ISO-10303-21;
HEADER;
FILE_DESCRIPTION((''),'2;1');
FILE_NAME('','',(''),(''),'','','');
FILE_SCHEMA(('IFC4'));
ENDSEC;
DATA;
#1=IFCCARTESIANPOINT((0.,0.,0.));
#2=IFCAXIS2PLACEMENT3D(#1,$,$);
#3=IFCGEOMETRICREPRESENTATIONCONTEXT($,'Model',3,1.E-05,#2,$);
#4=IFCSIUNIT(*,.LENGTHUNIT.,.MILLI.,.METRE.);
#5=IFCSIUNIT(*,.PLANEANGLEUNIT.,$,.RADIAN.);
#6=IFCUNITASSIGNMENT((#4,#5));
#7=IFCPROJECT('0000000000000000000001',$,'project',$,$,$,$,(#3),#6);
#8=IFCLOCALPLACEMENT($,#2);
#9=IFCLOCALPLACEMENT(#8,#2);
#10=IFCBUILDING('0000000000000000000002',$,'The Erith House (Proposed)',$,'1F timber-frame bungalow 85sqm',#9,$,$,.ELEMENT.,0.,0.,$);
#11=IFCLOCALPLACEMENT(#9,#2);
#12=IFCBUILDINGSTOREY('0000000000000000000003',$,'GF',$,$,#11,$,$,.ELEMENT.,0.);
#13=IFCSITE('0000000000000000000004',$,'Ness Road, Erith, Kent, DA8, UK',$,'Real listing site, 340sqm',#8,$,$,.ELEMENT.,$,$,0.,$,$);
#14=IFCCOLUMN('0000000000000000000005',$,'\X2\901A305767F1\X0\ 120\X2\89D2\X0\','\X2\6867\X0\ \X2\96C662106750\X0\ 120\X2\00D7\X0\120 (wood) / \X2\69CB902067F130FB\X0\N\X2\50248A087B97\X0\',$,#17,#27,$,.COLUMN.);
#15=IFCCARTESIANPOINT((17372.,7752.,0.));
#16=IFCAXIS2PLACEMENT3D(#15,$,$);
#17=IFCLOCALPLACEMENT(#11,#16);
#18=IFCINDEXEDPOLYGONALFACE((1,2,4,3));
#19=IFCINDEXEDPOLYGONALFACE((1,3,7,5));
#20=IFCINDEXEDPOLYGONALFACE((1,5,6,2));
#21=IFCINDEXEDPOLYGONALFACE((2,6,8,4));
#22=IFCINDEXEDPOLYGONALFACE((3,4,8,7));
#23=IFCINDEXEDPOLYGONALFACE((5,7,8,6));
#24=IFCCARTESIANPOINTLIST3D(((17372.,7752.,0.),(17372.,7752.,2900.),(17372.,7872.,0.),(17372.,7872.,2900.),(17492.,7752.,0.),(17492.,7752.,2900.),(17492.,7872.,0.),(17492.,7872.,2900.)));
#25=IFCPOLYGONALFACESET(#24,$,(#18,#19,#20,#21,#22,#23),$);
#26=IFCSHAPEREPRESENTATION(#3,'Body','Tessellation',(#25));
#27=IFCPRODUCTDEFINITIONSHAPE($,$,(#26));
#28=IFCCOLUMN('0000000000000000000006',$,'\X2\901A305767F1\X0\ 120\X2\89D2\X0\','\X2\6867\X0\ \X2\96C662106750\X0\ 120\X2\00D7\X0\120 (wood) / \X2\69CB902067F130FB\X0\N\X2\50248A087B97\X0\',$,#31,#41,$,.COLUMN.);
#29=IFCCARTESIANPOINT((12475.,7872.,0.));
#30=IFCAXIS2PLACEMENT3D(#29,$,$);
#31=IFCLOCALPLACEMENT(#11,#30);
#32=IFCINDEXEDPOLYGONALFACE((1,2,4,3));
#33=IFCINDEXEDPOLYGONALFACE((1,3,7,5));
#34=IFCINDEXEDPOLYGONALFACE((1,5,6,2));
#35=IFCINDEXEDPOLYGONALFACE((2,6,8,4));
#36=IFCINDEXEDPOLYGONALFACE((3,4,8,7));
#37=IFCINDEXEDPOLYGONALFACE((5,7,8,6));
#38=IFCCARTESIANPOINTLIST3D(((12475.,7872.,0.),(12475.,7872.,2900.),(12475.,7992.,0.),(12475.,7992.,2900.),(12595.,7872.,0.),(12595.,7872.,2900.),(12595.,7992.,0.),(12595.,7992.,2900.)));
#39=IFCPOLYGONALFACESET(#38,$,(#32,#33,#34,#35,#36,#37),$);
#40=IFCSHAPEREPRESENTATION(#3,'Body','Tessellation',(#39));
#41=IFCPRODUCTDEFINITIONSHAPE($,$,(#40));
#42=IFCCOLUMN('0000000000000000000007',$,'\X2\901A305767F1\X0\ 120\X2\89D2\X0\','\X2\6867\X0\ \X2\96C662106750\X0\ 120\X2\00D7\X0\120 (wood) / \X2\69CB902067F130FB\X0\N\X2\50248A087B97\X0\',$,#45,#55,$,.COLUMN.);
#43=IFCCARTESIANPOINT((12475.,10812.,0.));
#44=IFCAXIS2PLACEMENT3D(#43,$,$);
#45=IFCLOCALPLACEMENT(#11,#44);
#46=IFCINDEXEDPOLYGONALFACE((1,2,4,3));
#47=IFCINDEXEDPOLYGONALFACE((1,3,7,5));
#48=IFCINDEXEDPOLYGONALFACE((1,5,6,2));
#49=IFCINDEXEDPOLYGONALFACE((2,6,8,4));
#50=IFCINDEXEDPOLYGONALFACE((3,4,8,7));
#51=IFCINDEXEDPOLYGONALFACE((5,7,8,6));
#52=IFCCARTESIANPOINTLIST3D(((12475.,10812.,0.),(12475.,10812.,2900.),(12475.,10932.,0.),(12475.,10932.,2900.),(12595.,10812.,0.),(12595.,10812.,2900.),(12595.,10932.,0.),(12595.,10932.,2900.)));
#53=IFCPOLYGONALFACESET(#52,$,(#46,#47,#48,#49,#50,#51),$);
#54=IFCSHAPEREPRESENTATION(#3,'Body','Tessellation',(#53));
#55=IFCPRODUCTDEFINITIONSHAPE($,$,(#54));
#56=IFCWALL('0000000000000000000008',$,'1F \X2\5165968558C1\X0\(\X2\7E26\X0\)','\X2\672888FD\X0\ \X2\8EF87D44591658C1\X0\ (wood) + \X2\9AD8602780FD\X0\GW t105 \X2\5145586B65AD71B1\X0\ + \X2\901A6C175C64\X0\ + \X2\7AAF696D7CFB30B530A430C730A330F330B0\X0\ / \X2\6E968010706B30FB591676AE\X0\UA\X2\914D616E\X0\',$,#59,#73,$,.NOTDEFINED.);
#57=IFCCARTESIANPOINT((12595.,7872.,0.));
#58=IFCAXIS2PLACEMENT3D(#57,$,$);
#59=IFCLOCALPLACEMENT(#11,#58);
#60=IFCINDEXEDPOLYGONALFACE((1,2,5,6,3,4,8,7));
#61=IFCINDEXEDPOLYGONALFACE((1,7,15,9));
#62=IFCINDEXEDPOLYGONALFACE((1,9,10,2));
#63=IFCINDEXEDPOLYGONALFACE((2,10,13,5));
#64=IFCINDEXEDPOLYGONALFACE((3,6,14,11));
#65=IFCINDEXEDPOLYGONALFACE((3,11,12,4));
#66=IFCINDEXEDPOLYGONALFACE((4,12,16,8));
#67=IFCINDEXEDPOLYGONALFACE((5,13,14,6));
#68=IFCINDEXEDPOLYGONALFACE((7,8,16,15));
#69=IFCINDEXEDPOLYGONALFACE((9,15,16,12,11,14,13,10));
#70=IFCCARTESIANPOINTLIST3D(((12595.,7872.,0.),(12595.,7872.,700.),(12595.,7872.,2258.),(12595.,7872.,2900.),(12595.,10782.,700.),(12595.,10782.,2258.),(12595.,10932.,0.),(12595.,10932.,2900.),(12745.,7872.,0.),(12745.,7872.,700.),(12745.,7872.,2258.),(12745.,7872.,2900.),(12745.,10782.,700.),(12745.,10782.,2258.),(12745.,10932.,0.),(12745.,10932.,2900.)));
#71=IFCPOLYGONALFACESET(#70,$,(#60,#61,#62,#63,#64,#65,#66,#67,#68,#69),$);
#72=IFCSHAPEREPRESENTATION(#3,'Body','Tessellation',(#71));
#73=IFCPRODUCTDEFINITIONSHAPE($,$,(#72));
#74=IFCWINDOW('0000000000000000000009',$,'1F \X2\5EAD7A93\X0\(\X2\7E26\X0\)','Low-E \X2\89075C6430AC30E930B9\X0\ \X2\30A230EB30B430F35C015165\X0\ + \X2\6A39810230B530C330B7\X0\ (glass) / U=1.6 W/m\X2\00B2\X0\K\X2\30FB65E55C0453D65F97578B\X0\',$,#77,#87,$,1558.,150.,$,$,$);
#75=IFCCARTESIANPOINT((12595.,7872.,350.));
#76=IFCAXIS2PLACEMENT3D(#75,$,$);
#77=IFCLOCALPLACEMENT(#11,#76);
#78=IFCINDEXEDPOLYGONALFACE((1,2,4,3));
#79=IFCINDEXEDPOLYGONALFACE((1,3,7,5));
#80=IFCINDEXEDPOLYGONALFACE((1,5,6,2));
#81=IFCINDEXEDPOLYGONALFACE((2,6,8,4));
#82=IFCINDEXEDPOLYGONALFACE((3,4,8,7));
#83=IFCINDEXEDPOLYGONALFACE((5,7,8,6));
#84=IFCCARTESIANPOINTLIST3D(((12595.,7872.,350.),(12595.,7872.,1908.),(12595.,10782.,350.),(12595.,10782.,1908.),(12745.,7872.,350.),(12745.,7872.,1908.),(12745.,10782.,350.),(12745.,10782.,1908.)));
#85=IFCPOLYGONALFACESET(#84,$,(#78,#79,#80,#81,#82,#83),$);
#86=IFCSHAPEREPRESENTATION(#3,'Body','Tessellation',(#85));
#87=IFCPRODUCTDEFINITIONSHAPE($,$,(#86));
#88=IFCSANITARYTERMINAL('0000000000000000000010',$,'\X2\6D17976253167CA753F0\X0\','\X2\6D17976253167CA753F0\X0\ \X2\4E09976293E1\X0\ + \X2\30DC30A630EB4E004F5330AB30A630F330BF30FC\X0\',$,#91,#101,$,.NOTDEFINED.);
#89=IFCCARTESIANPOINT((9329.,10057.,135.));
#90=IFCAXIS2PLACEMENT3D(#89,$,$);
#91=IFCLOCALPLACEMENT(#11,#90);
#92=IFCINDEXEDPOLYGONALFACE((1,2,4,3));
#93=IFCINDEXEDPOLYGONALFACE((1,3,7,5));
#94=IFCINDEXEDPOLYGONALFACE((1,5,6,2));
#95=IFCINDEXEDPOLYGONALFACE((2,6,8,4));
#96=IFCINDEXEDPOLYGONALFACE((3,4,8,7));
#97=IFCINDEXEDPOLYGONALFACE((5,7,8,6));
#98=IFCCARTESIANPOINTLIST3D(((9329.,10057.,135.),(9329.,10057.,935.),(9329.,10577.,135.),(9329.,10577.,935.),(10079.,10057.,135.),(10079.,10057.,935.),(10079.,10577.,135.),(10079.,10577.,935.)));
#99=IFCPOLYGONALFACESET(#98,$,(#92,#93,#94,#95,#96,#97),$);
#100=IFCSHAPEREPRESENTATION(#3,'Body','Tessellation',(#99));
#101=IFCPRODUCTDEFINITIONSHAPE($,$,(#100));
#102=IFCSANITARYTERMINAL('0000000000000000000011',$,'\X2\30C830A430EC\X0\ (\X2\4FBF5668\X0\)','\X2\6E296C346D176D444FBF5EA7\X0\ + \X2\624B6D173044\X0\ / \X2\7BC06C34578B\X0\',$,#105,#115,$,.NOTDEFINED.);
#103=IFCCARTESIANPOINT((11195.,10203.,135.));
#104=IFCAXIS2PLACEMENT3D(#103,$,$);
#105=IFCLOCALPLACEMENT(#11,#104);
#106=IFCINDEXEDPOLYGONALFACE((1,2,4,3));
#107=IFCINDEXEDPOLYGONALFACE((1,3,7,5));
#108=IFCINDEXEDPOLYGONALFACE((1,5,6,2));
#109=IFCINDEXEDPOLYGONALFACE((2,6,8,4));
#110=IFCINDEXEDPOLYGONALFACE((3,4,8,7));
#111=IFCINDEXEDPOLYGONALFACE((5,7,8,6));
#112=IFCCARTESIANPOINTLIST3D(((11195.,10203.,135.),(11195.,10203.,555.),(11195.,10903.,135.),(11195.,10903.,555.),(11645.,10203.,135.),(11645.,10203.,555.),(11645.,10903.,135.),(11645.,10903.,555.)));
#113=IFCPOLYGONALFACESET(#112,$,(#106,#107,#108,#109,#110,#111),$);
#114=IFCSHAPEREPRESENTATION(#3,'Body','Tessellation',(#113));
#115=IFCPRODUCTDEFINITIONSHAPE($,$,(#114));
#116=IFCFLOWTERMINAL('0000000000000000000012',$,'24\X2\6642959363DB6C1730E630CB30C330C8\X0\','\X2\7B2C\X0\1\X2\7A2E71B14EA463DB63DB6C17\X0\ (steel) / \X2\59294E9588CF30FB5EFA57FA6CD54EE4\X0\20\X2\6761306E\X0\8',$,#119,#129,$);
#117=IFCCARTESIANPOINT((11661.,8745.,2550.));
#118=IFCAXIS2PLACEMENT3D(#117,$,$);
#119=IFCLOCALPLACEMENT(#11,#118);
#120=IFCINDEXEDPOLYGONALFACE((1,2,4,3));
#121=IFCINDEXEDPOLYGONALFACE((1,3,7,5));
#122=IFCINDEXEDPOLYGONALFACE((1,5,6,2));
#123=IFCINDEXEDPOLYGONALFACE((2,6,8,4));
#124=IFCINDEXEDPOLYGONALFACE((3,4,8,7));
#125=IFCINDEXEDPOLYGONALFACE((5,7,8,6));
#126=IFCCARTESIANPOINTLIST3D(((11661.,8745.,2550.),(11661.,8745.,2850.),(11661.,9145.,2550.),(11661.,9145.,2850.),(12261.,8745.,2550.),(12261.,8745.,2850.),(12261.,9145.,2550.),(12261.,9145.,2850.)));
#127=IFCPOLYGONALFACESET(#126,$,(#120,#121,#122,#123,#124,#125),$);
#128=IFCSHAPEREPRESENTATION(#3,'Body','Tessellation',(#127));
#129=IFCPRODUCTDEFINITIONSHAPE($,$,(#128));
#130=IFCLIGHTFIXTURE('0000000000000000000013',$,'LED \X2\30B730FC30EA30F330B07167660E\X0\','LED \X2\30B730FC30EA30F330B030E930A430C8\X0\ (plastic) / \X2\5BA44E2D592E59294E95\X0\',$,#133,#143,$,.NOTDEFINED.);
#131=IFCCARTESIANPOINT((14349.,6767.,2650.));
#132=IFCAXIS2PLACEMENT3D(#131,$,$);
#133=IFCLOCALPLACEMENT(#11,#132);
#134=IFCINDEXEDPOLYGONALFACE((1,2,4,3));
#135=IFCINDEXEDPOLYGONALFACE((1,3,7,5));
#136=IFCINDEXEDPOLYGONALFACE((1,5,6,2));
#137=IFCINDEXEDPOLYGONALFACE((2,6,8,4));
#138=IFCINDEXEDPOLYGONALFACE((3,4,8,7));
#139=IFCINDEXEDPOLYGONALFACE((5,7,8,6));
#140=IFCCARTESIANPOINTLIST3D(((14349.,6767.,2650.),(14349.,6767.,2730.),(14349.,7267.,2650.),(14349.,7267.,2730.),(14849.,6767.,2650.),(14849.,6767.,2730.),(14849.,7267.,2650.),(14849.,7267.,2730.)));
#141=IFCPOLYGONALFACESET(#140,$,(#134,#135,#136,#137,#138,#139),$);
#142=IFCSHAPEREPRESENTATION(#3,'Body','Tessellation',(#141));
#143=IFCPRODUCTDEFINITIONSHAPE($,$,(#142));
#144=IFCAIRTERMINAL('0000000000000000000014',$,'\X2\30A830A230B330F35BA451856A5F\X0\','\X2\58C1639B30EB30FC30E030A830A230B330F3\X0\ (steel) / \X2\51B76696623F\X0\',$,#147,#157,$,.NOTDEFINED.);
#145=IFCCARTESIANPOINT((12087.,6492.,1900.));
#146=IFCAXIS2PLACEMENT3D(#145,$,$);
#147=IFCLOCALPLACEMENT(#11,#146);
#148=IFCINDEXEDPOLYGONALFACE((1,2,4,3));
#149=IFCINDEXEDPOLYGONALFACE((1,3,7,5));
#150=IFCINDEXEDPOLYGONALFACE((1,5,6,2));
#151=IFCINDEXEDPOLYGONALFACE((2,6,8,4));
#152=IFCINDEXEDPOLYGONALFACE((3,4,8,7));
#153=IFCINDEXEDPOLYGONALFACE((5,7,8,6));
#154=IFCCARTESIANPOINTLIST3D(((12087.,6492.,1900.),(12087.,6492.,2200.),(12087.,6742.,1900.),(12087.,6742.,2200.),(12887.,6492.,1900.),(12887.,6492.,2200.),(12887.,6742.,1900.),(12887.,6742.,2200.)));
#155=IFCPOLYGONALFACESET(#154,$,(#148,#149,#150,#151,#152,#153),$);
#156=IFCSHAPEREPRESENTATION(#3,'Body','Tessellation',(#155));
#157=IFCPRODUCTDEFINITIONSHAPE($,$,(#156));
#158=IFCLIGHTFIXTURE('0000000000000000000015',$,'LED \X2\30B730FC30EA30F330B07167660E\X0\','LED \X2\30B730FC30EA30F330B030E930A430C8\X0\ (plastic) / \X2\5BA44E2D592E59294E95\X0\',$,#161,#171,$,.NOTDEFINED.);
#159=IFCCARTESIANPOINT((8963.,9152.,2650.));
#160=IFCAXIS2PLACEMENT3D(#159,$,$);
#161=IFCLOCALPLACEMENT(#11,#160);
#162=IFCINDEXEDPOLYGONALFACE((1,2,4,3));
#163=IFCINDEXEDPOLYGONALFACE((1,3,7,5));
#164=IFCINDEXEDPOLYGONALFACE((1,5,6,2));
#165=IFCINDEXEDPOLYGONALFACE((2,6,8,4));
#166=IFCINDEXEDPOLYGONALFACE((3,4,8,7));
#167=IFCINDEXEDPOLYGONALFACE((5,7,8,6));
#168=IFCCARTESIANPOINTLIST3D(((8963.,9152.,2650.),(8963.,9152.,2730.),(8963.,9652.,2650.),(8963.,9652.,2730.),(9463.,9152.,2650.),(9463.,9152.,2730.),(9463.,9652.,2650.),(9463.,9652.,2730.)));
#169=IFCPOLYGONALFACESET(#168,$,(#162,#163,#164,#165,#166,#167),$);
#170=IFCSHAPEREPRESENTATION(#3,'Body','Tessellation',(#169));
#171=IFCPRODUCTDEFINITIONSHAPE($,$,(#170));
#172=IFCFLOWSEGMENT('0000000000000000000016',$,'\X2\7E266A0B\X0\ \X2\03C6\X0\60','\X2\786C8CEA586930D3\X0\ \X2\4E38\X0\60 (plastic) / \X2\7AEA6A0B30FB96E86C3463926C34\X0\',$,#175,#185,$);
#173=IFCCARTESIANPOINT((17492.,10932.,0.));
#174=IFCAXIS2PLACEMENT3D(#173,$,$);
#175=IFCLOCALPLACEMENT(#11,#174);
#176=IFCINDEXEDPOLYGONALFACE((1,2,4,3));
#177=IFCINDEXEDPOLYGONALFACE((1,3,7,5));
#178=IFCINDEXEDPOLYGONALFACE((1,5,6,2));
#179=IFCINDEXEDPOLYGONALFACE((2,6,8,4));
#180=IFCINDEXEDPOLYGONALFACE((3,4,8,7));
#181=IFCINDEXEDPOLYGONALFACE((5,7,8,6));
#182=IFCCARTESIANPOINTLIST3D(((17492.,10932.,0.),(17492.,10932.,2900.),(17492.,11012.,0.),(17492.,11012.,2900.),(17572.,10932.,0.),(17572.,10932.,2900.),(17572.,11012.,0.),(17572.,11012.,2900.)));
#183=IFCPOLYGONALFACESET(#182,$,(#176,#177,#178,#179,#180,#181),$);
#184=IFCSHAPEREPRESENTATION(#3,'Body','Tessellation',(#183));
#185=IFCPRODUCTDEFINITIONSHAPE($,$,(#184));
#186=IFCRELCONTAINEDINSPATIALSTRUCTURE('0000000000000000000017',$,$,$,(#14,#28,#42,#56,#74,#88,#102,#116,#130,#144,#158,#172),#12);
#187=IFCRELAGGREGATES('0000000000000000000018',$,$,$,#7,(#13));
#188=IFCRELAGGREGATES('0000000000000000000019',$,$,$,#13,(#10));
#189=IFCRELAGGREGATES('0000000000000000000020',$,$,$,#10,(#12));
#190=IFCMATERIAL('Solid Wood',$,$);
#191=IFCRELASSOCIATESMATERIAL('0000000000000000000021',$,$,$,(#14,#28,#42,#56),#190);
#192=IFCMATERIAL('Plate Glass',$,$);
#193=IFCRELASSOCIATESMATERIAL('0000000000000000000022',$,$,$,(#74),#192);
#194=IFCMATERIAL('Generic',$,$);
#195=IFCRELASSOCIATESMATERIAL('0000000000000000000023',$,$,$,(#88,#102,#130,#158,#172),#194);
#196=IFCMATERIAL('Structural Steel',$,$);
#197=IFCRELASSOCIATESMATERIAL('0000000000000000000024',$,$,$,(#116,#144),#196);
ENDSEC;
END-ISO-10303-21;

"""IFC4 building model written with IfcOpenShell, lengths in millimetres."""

from ifc_helpers import new_model, si_unit, frame, frame_2d, origin, place, context, project, spatial, rectangle, extrude, material, element, fill, save


model = new_model("IFC4")

# Units and contexts
model_context = context("Model", 3, precision=1e-05, world=origin())
ifc_project = project(units=[si_unit("LENGTHUNIT", "METRE", prefix="MILLI"), si_unit("PLANEANGLEUNIT", "RADIAN")], contexts=[model_context])

# Site, building, storey
site_placement = place(None, origin())
site = spatial("IfcSite", under=ifc_project, at=site_placement, Name="Ness Road, Erith, Kent, DA8, UK", ObjectType="Real listing site, 340sqm", CompositionType="ELEMENT", RefElevation=0.0)
building_placement = place(site_placement, origin())
building = spatial("IfcBuilding", under=site, at=building_placement, Name="The Erith House (Proposed)", ObjectType="1F timber-frame bungalow 85sqm", CompositionType="ELEMENT", ElevationOfRefHeight=0.0, ElevationOfTerrain=0.0)
storey_placement = place(building_placement, origin())
storey = spatial("IfcBuildingStorey", under=building, at=storey_placement, Name="GF", CompositionType="ELEMENT", Elevation=0.0)

# Columns
ifc_material_1 = material(Name="Solid Wood")
column_1_placement = place(storey_placement, frame((17372.0, 7752.0, 0.0)))
element("IfcColumn", 1, at=column_1_placement, inside=storey, material=ifc_material_1, Name="通し柱 120角", Description="桧 集成材 120×120 (wood) / 構造柱・N値計算", PredefinedType="COLUMN", context=model_context, shape_type="SweptSolid", body=[
    extrude(rectangle(XDim=120.0, YDim=120.0, at=frame_2d((60.0, 60.0))), frame((17372.0, 7752.0, 0.0)), (0.0, 0.0, 1.0), 2900.0),
])
column_2_placement = place(storey_placement, frame((12475.0, 7872.0, 0.0)))
element("IfcColumn", 2, at=column_2_placement, inside=storey, material=ifc_material_1, Name="通し柱 120角", Description="桧 集成材 120×120 (wood) / 構造柱・N値計算", PredefinedType="COLUMN", context=model_context, shape_type="SweptSolid", body=[
    extrude(rectangle(XDim=120.0, YDim=120.0, at=frame_2d((60.0, 60.0))), frame((12475.0, 7872.0, 0.0)), (0.0, 0.0, 1.0), 2900.0),
])
column_3_placement = place(storey_placement, frame((12475.0, 10812.0, 0.0)))
element("IfcColumn", 3, at=column_3_placement, inside=storey, material=ifc_material_1, Name="通し柱 120角", Description="桧 集成材 120×120 (wood) / 構造柱・N値計算", PredefinedType="COLUMN", context=model_context, shape_type="SweptSolid", body=[
    extrude(rectangle(XDim=120.0, YDim=120.0, at=frame_2d((60.0, 60.0))), frame((12475.0, 10812.0, 0.0)), (0.0, 0.0, 1.0), 2900.0),
])

# Wall, opening, window
wall_1_placement = place(storey_placement, frame((12595.0, 7872.0, 0.0)))
wall_1 = element("IfcWall", 4, at=wall_1_placement, inside=storey, material=ifc_material_1, Name="1F 入隅壁(縦)", Description="木製 軸組外壁 (wood) + 高性能GW t105 充填断熱 + 通気層 + 窯業系サイディング / 準耐火・外皮UA配慮", PredefinedType="NOTDEFINED", context=model_context, shape_type="SweptSolid", body=[
    extrude(rectangle(XDim=150.0, YDim=3060.0, at=frame_2d((75.0, 1530.0))), frame((12595.0, 7872.0, 0.0)), (0.0, 0.0, 1.0), 2900.0),
])
opening_placement = place(storey_placement, frame((12595.0, 7872.0, 350.0)))
opening = element("IfcOpeningElement", 5, at=opening_placement, cuts=wall_1, PredefinedType="NOTDEFINED", context=model_context, shape_type="SweptSolid", body=[
    extrude(rectangle(XDim=150.0, YDim=2910.0, at=frame_2d((75.0, 1455.0))), frame((12595.0, 7872.0, 350.0)), (0.0, 0.0, 1.0), 1558.0),
])
ifc_material_2 = material(Name="Plate Glass")
window_placement = place(storey_placement, frame((12595.0, 7872.0, 350.0)))
window = element("IfcWindow", 6, at=window_placement, inside=storey, material=ifc_material_2, Name="1F 庭窓(縦)", Description="Low-E 複層ガラス アルゴン封入 + 樹脂サッシ (glass) / U=1.6 W/m²K・日射取得型", OverallHeight=1558.0, OverallWidth=150.0, context=model_context, shape_type="SweptSolid", body=[
    extrude(rectangle(XDim=150.0, YDim=2910.0, at=frame_2d((75.0, 1455.0))), frame((12595.0, 7872.0, 350.0)), (0.0, 0.0, 1.0), 1558.0),
])
fill(opening, window)

# Sanitary terminals
ifc_material_3 = material(Name="Generic")
sanitary_terminal_1_placement = place(storey_placement, frame((9329.0, 10057.0, 135.0)))
element("IfcSanitaryTerminal", 7, at=sanitary_terminal_1_placement, inside=storey, material=ifc_material_3, Name="洗面化粧台", Description="洗面化粧台 三面鏡 + ボウル一体カウンター", PredefinedType="NOTDEFINED", context=model_context, shape_type="SweptSolid", body=[
    extrude(rectangle(XDim=750.0, YDim=520.0, at=frame_2d((375.0, 260.0))), frame((9329.0, 10057.0, 135.0)), (0.0, 0.0, 1.0), 800.0),
])
sanitary_terminal_2_placement = place(storey_placement, frame((11195.0, 10203.0, 135.0)))
element("IfcSanitaryTerminal", 8, at=sanitary_terminal_2_placement, inside=storey, material=ifc_material_3, Name="トイレ (便器)", Description="温水洗浄便座 + 手洗い / 節水型", PredefinedType="NOTDEFINED", context=model_context, shape_type="SweptSolid", body=[
    extrude(rectangle(XDim=450.0, YDim=700.0, at=frame_2d((225.0, 350.0))), frame((11195.0, 10203.0, 135.0)), (0.0, 0.0, 1.0), 420.0),
])

# Flow terminal
ifc_material_4 = material(Name="Structural Steel")
flow_terminal_placement = place(storey_placement, frame((11661.0, 8745.0, 2550.0)))
element("IfcFlowTerminal", 9, at=flow_terminal_placement, inside=storey, material=ifc_material_4, Name="24時間換気ユニット", Description="第1種熱交換換気 (steel) / 天井裏・建基法令20条の8", context=model_context, shape_type="SweptSolid", body=[
    extrude(rectangle(XDim=600.0, YDim=400.0, at=frame_2d((300.0, 200.0))), frame((11661.0, 8745.0, 2550.0)), (0.0, 0.0, 1.0), 300.0),
])

# Light fixture
light_fixture_1_placement = place(storey_placement, frame((14349.0, 6767.0, 2650.0)))
element("IfcLightFixture", 10, at=light_fixture_1_placement, inside=storey, material=ifc_material_3, Name="LED シーリング照明", Description="LED シーリングライト (plastic) / 室中央天井", PredefinedType="NOTDEFINED", context=model_context, shape_type="SweptSolid", body=[
    extrude(rectangle(XDim=500.0, YDim=500.0, at=frame_2d((250.0, 250.0))), frame((14349.0, 6767.0, 2650.0)), (0.0, 0.0, 1.0), 80.0),
])

# Air terminal
air_terminal_placement = place(storey_placement, frame((12087.0, 6492.0, 1900.0)))
element("IfcAirTerminal", 11, at=air_terminal_placement, inside=storey, material=ifc_material_4, Name="エアコン室内機", Description="壁掛ルームエアコン (steel) / 冷暖房", PredefinedType="NOTDEFINED", context=model_context, shape_type="SweptSolid", body=[
    extrude(rectangle(XDim=800.0, YDim=250.0, at=frame_2d((400.0, 125.0))), frame((12087.0, 6492.0, 1900.0)), (0.0, 0.0, 1.0), 300.0),
])

# Light fixture
light_fixture_2_placement = place(storey_placement, frame((8963.0, 9152.0, 2650.0)))
element("IfcLightFixture", 12, at=light_fixture_2_placement, inside=storey, material=ifc_material_3, Name="LED シーリング照明", Description="LED シーリングライト (plastic) / 室中央天井", PredefinedType="NOTDEFINED", context=model_context, shape_type="SweptSolid", body=[
    extrude(rectangle(XDim=500.0, YDim=500.0, at=frame_2d((250.0, 250.0))), frame((8963.0, 9152.0, 2650.0)), (0.0, 0.0, 1.0), 80.0),
])

# Flow segment
flow_segment_placement = place(storey_placement, frame((17492.0, 10932.0, 0.0)))
element("IfcFlowSegment", 13, at=flow_segment_placement, inside=storey, material=ifc_material_3, Name="縦樋 φ60", Description="硬質塩ビ 丸60 (plastic) / 竪樋・雨水排水", context=model_context, shape_type="SweptSolid", body=[
    extrude(rectangle(XDim=80.0, YDim=80.0, at=frame_2d((40.0, 40.0))), frame((17492.0, 10932.0, 0.0)), (0.0, 0.0, 1.0), 2900.0),
])

save(model, "model.ifc")
